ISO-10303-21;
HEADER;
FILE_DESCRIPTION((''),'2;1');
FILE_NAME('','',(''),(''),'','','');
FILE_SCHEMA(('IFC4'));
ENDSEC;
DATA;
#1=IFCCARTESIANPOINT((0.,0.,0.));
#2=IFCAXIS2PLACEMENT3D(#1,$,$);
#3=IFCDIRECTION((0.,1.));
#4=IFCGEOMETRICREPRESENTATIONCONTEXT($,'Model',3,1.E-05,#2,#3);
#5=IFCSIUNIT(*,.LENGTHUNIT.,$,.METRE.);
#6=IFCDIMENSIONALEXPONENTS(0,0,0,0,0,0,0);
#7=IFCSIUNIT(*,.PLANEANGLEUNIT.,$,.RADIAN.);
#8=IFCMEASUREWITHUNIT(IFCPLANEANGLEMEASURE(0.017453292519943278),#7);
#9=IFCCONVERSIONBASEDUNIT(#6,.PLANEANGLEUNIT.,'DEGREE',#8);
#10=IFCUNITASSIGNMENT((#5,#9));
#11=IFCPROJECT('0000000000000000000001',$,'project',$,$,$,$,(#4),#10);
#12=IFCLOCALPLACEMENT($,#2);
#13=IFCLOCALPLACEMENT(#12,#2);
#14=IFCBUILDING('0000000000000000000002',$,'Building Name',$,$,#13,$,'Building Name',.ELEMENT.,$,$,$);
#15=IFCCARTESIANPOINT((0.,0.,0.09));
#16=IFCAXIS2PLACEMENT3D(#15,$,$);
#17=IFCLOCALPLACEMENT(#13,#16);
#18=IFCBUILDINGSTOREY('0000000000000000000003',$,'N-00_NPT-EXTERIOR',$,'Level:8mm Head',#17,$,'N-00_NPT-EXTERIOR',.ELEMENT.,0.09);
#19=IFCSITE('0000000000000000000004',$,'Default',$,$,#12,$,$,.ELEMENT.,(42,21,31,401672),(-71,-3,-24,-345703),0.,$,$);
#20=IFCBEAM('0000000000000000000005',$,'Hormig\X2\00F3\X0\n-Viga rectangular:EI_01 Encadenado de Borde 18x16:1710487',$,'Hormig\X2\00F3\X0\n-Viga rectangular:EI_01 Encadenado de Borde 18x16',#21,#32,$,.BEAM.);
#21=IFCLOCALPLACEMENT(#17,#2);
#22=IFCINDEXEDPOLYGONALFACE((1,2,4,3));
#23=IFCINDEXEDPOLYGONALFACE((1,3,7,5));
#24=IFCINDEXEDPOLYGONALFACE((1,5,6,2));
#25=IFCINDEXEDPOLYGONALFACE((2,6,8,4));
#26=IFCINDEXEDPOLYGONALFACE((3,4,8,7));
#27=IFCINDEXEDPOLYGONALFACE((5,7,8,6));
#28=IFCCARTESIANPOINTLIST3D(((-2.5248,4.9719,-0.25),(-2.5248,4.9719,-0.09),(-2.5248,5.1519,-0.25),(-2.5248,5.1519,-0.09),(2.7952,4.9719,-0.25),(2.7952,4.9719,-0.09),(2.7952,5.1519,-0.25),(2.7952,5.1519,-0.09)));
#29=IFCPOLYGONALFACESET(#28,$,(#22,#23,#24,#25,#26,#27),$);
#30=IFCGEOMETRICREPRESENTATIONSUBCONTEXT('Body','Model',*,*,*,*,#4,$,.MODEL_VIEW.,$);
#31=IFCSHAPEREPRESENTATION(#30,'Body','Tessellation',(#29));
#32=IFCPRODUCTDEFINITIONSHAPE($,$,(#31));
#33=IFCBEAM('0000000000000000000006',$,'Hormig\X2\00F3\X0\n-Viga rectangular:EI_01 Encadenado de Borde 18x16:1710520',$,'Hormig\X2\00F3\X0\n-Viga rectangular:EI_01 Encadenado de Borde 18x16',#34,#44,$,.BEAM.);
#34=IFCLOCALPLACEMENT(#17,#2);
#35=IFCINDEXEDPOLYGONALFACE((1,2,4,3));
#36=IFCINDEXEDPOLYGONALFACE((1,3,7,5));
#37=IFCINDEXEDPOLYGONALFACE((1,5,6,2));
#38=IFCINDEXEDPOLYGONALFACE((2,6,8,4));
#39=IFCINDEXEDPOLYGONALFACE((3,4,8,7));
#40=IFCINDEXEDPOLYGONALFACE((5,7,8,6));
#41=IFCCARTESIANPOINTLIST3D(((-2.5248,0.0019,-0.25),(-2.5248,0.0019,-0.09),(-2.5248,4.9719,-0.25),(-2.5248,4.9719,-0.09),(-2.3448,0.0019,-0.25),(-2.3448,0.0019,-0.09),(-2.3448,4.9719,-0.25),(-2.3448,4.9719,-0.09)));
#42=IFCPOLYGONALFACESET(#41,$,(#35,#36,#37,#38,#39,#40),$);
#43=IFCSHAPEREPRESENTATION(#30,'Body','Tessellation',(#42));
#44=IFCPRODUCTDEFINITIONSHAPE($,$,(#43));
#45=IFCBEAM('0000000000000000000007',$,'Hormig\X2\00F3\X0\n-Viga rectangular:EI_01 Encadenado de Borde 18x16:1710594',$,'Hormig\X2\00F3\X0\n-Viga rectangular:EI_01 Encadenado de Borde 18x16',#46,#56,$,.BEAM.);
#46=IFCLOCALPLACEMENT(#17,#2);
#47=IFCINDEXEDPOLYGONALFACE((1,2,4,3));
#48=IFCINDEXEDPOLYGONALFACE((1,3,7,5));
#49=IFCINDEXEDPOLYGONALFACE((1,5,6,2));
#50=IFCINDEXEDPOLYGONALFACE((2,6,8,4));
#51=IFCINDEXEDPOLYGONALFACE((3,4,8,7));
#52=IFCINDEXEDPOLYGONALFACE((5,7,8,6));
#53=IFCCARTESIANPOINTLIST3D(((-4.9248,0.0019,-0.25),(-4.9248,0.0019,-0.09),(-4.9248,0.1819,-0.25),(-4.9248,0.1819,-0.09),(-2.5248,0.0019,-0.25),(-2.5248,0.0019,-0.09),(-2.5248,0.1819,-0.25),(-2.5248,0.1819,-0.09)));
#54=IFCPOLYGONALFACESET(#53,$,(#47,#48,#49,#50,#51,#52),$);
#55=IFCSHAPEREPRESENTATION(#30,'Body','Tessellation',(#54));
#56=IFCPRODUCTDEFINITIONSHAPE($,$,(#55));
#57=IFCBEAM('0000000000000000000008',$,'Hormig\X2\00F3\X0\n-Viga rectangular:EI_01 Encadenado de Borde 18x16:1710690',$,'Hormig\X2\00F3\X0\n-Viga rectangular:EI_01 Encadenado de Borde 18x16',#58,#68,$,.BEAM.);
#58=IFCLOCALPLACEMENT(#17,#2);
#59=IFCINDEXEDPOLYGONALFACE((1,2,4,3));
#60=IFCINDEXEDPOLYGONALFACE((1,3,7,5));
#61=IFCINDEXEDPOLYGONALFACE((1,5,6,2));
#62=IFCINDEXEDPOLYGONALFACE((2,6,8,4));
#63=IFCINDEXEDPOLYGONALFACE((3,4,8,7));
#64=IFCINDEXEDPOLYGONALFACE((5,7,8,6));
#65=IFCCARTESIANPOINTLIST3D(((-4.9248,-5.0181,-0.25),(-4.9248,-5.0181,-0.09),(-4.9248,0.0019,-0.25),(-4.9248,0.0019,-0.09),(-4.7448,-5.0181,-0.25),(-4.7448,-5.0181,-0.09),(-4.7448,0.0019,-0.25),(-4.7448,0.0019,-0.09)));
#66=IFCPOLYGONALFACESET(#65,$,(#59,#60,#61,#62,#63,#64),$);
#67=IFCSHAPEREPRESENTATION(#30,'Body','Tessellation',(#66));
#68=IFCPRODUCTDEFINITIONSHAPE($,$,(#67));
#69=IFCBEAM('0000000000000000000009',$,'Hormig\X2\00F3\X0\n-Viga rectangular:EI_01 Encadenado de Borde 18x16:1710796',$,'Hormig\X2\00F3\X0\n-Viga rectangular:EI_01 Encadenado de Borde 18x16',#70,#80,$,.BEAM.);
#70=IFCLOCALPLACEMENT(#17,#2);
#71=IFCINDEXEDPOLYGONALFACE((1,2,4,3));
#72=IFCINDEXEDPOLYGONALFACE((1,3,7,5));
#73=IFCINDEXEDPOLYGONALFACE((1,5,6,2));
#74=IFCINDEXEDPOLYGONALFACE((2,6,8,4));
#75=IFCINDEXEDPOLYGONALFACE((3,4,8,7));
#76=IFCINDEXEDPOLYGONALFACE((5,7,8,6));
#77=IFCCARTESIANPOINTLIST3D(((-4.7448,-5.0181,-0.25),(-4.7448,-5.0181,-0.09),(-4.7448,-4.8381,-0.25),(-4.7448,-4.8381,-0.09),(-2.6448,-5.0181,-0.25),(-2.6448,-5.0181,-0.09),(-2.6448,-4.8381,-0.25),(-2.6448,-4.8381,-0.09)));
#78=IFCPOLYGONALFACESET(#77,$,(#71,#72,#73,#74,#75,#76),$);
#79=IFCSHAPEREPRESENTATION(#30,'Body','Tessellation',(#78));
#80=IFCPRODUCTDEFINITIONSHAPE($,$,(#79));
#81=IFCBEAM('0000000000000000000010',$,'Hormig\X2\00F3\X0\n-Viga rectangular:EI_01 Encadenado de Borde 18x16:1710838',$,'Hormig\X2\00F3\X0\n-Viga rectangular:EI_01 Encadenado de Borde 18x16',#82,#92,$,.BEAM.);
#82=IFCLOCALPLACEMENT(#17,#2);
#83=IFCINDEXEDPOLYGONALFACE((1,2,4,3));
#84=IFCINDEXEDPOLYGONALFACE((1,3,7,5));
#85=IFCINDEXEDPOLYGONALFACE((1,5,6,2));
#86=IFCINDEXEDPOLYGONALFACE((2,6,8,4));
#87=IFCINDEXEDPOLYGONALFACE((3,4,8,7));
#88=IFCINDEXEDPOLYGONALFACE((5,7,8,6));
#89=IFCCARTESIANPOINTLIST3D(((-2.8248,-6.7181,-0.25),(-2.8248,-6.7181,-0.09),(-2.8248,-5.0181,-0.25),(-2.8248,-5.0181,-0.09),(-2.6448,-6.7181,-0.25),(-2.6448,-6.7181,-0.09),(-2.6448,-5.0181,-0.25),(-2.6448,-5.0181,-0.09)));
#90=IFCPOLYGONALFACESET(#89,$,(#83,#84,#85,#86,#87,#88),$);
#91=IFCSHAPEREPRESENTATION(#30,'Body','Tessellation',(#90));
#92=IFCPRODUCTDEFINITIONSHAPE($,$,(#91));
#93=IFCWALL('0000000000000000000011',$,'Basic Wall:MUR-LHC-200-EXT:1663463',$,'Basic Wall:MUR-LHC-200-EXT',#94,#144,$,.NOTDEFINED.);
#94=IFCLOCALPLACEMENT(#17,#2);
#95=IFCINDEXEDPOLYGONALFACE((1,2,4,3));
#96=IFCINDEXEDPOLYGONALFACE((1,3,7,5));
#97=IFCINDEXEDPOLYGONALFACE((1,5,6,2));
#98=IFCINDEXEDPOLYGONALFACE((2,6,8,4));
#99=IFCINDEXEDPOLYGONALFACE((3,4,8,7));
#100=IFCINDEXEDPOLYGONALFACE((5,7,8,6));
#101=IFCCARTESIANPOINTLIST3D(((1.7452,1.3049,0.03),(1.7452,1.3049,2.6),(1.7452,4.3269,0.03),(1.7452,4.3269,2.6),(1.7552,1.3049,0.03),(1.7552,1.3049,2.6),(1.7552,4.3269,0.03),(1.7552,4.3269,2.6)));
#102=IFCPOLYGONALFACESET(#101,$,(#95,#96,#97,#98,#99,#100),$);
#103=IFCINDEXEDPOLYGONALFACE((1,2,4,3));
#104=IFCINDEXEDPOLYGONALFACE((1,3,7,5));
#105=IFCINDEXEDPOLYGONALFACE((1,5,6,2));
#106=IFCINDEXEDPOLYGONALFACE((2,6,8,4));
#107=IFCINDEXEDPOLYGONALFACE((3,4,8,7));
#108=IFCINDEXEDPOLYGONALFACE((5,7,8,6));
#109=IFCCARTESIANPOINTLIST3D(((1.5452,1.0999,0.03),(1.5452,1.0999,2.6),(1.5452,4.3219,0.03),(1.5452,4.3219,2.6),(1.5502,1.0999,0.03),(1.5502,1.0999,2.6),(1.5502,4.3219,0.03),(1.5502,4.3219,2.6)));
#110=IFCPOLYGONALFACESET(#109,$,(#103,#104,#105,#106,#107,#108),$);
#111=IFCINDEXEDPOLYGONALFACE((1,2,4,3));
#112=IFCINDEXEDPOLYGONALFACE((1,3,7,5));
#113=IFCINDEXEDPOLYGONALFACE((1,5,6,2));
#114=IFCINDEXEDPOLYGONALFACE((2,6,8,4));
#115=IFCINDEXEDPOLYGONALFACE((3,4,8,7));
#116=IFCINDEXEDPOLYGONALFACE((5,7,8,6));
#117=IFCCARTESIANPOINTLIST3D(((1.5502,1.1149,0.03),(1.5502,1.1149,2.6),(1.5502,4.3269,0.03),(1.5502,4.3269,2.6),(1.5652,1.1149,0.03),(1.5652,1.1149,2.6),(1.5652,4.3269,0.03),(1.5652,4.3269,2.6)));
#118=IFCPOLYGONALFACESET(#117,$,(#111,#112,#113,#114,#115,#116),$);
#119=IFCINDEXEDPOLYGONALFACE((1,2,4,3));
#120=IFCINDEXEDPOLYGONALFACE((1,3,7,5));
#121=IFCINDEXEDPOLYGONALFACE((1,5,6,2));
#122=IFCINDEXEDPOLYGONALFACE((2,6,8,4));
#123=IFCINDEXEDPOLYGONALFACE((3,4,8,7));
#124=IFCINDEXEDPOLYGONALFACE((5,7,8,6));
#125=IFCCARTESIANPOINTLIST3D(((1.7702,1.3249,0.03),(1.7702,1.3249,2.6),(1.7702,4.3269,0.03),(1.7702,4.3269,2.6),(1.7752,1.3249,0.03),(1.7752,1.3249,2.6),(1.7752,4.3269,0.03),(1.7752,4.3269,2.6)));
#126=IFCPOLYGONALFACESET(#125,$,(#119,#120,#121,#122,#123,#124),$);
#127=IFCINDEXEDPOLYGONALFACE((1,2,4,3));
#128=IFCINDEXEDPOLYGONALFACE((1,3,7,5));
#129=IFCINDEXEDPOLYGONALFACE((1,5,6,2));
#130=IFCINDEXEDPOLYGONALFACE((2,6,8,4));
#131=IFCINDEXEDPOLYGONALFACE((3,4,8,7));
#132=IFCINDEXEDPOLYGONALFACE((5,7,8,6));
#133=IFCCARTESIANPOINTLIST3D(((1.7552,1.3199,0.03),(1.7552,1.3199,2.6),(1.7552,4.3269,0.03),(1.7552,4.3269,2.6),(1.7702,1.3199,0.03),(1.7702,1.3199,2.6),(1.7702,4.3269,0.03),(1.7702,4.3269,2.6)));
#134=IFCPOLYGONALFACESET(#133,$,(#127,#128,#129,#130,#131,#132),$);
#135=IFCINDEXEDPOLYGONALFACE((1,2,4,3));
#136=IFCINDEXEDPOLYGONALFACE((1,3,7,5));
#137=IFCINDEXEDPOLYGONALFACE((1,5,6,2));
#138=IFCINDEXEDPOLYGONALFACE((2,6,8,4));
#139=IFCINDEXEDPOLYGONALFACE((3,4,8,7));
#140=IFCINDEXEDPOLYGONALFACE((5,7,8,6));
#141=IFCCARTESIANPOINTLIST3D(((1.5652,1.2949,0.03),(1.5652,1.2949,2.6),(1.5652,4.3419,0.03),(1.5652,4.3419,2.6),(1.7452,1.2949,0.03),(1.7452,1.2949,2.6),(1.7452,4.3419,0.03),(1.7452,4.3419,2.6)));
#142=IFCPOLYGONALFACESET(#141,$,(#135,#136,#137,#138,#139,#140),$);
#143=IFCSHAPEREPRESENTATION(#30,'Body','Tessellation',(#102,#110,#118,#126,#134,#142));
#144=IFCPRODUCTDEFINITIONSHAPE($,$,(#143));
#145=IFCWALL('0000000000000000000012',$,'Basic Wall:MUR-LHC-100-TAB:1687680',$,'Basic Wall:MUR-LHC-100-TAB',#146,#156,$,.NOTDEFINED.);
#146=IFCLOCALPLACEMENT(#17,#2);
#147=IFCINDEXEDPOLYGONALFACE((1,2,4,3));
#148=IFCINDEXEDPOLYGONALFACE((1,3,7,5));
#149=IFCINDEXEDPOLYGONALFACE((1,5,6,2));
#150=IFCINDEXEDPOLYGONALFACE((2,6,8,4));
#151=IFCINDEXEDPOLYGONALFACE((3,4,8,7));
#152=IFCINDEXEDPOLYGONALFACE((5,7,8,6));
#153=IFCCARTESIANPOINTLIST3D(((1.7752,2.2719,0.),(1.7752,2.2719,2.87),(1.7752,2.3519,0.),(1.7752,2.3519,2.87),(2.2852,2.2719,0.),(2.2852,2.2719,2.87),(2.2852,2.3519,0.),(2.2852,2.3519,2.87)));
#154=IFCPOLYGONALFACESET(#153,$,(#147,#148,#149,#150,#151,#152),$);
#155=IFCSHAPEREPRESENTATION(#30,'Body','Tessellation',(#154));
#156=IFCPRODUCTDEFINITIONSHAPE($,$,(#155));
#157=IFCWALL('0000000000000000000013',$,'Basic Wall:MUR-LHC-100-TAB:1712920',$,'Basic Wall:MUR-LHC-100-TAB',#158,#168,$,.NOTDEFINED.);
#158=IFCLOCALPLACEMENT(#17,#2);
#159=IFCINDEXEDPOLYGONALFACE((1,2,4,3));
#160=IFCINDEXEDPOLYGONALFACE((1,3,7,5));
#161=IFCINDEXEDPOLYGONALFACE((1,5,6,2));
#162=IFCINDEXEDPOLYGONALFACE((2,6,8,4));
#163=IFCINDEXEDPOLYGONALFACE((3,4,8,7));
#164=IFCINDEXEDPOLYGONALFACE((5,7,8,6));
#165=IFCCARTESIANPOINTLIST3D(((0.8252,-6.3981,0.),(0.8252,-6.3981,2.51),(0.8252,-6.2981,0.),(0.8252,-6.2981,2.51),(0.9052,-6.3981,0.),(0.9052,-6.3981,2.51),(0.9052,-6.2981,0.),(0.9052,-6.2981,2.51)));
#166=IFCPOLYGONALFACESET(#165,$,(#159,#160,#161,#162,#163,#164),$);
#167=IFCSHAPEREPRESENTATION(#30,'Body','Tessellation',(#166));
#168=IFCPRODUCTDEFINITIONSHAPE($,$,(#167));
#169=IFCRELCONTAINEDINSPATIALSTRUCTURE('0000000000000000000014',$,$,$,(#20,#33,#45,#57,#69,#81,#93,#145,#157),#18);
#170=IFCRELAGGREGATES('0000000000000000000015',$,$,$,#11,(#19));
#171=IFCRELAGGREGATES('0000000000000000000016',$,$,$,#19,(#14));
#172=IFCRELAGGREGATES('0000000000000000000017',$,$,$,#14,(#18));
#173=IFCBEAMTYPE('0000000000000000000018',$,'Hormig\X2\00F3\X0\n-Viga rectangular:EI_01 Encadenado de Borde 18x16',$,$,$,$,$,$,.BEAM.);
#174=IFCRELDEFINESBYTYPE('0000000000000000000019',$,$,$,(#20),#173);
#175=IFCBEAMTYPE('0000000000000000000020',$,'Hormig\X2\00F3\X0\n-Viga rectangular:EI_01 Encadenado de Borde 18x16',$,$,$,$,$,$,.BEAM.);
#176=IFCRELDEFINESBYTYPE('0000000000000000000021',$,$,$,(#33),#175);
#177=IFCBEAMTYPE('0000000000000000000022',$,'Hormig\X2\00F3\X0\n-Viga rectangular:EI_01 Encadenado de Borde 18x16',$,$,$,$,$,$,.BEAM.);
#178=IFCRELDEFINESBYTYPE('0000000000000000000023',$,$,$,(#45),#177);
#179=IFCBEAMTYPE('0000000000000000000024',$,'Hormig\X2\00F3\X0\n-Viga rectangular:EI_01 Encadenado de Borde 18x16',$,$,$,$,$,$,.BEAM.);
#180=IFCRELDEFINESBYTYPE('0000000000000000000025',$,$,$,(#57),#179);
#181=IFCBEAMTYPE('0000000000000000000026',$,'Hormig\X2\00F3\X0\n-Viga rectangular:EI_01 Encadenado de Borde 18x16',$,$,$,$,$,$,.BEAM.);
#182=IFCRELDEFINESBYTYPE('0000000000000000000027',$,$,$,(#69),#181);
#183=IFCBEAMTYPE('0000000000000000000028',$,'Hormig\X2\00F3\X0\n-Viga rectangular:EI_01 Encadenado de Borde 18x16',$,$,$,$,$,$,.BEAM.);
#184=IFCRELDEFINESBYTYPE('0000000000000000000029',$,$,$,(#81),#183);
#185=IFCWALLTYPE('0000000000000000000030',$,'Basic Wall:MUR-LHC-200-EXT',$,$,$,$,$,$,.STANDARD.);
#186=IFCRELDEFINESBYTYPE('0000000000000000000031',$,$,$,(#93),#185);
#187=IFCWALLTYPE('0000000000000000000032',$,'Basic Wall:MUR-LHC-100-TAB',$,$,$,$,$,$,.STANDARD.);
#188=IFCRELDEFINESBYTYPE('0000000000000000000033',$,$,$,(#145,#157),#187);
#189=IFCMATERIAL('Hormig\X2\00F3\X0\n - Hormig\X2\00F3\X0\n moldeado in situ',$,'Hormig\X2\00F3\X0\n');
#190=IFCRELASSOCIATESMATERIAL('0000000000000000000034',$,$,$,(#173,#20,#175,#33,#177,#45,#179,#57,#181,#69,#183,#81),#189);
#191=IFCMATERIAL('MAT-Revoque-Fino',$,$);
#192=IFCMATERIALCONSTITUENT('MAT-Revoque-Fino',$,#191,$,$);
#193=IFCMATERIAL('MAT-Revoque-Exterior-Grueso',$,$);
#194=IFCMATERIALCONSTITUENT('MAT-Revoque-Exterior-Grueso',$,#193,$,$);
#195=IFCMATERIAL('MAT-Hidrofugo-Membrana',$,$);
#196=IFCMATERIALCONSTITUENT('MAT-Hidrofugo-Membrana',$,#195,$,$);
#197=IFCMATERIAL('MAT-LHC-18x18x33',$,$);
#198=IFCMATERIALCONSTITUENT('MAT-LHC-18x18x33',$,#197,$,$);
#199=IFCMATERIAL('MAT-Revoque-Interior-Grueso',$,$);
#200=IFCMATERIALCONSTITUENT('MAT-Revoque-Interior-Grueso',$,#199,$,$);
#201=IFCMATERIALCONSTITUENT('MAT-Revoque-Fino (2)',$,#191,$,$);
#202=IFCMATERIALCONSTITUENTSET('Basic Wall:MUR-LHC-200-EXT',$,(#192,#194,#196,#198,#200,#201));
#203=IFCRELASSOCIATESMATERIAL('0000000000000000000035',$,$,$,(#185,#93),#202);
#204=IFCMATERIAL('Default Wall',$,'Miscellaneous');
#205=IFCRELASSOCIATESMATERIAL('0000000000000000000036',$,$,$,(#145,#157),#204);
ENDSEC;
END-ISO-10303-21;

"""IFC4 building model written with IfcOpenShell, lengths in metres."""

from ifc_helpers import new_model, entity, si_unit, converted_unit, direction, frame, origin, place, context, subcontext, project, spatial, indexed_curve, outline, extrude, source, transform, mapped, material, constituent, constituent_set, type_object, type_shapes, element, save


model = new_model("IFC4")

# Units and contexts
model_context = context("Model", 3, precision=1e-05, world=origin(), true_north=direction((0.0, 1.0)))
body_context = subcontext(model_context, "Body", "Model", "MODEL_VIEW")
ifc_project = project(units=[si_unit("LENGTHUNIT", "METRE"), converted_unit("PLANEANGLEUNIT", "DEGREE", entity("IfcPlaneAngleMeasure", 0.017453292519943278), si_unit("PLANEANGLEUNIT", "RADIAN"), dimensions=[0, 0, 0, 0, 0, 0, 0])], contexts=[model_context])

# Site, building, storey
site_placement = place(None, origin())
site = spatial("IfcSite", under=ifc_project, at=site_placement, Name="Default", CompositionType="ELEMENT", RefLatitude=(42, 21, 31, 401672), RefLongitude=(-71, -3, -24, -345703), RefElevation=0.0)
building_placement = place(site_placement, origin())
building = spatial("IfcBuilding", under=site, at=building_placement, Name="Building Name", LongName="Building Name", CompositionType="ELEMENT")
storey_placement = place(building_placement, frame((0.0, 0.0, 0.09)))
storey = spatial("IfcBuildingStorey", under=building, at=storey_placement, Name="N-00_NPT-EXTERIOR", ObjectType="Level:8mm Head", LongName="N-00_NPT-EXTERIOR", CompositionType="ELEMENT", Elevation=0.09)

# Beams
ifc_material_1 = material(Name="Hormigón - Hormigón moldeado in situ", Category="Hormigón")
beam_type_1 = type_object("IfcBeamType", Name="Hormigón-Viga rectangular:EI_01 Encadenado de Borde 18x16", PredefinedType="BEAM", material=ifc_material_1)
shared_shape_1 = source(origin(), body_context, "Body", "SweptSolid", [
    extrude(outline(indexed_curve([(-0.08, -0.09), (0.08, -0.09), (0.08, 0.09), (-0.08, 0.09), (-0.08, -0.09)], self_intersect=False)), frame((2.7952, 5.0619, -0.08), z_axis=(-1.0, 0.0, 0.0), x_axis=(0.0, 0.0, -1.0)), (0.0, 0.0, 1.0), 5.32),
])
type_shapes(beam_type_1, [shared_shape_1])
beam_1_placement = place(storey_placement, frame((0.0, 0.0, -0.09)))
element("IfcBeam", 1, at=beam_1_placement, inside=storey, type_object=beam_type_1, material=ifc_material_1, Name="Hormigón-Viga rectangular:EI_01 Encadenado de Borde 18x16:1710487", ObjectType="Hormigón-Viga rectangular:EI_01 Encadenado de Borde 18x16", PredefinedType="BEAM", context=body_context, shape_type="MappedRepresentation", body=[
    mapped(shared_shape_1, transform((0.0, 0.0, 0.0), scale=1.0)),
])
beam_type_2 = type_object("IfcBeamType", Name="Hormigón-Viga rectangular:EI_01 Encadenado de Borde 18x16", PredefinedType="BEAM", material=ifc_material_1)
shared_shape_2 = source(origin(), body_context, "Body", "SweptSolid", [
    extrude(outline(indexed_curve([(-0.09, -0.08), (0.09, -0.08), (0.09, 0.08), (-0.09, 0.08), (-0.09, -0.08)], self_intersect=False)), frame((-2.4348, 4.9719, -0.08), z_axis=(0.0, -1.0, 0.0), x_axis=(-1.0, 0.0, 0.0)), (0.0, 0.0, 1.0), 4.97),
])
type_shapes(beam_type_2, [shared_shape_2])
beam_2_placement = place(storey_placement, frame((0.0, 0.0, -0.09)))
element("IfcBeam", 2, at=beam_2_placement, inside=storey, type_object=beam_type_2, material=ifc_material_1, Name="Hormigón-Viga rectangular:EI_01 Encadenado de Borde 18x16:1710520", ObjectType="Hormigón-Viga rectangular:EI_01 Encadenado de Borde 18x16", PredefinedType="BEAM", context=body_context, shape_type="MappedRepresentation", body=[
    mapped(shared_shape_2, transform((0.0, 0.0, 0.0), scale=1.0)),
])
beam_type_3 = type_object("IfcBeamType", Name="Hormigón-Viga rectangular:EI_01 Encadenado de Borde 18x16", PredefinedType="BEAM", material=ifc_material_1)
shared_shape_3 = source(origin(), body_context, "Body", "SweptSolid", [
    extrude(outline(indexed_curve([(-0.08, -0.09), (0.08, -0.09), (0.08, 0.09), (-0.08, 0.09), (-0.08, -0.09)], self_intersect=False)), frame((-2.5248, 0.0919, -0.08), z_axis=(-1.0, 0.0, 0.0), x_axis=(0.0, 0.0, -1.0)), (0.0, 0.0, 1.0), 2.4),
])
type_shapes(beam_type_3, [shared_shape_3])
beam_3_placement = place(storey_placement, frame((0.0, 0.0, -0.09)))
element("IfcBeam", 3, at=beam_3_placement, inside=storey, type_object=beam_type_3, material=ifc_material_1, Name="Hormigón-Viga rectangular:EI_01 Encadenado de Borde 18x16:1710594", ObjectType="Hormigón-Viga rectangular:EI_01 Encadenado de Borde 18x16", PredefinedType="BEAM", context=body_context, shape_type="MappedRepresentation", body=[
    mapped(shared_shape_3, transform((0.0, 0.0, 0.0), scale=1.0)),
])
beam_type_4 = type_object("IfcBeamType", Name="Hormigón-Viga rectangular:EI_01 Encadenado de Borde 18x16", PredefinedType="BEAM", material=ifc_material_1)
shared_shape_4 = source(origin(), body_context, "Body", "SweptSolid", [
    extrude(outline(indexed_curve([(-0.09, -0.08), (0.09, -0.08), (0.09, 0.08), (-0.09, 0.08), (-0.09, -0.08)], self_intersect=False)), frame((-4.8348, 0.0019, -0.08), z_axis=(0.0, -1.0, 0.0), x_axis=(-1.0, 0.0, 0.0)), (0.0, 0.0, 1.0), 5.02),
])
type_shapes(beam_type_4, [shared_shape_4])
beam_4_placement = place(storey_placement, frame((0.0, 0.0, -0.09)))
element("IfcBeam", 4, at=beam_4_placement, inside=storey, type_object=beam_type_4, material=ifc_material_1, Name="Hormigón-Viga rectangular:EI_01 Encadenado de Borde 18x16:1710690", ObjectType="Hormigón-Viga rectangular:EI_01 Encadenado de Borde 18x16", PredefinedType="BEAM", context=body_context, shape_type="MappedRepresentation", body=[
    mapped(shared_shape_4, transform((0.0, 0.0, 0.0), scale=1.0)),
])
beam_type_5 = type_object("IfcBeamType", Name="Hormigón-Viga rectangular:EI_01 Encadenado de Borde 18x16", PredefinedType="BEAM", material=ifc_material_1)
shared_shape_5 = source(origin(), body_context, "Body", "SweptSolid", [
    extrude(outline(indexed_curve([(-0.08, -0.09), (0.08, -0.09), (0.08, 0.09), (-0.08, 0.09), (-0.08, -0.09)], self_intersect=False)), frame((-4.7448, -4.9281, -0.08), z_axis=(1.0, 0.0, 0.0), x_axis=(0.0, 0.0, -1.0)), (0.0, 0.0, 1.0), 2.1),
])
type_shapes(beam_type_5, [shared_shape_5])
beam_5_placement = place(storey_placement, frame((0.0, 0.0, -0.09)))
element("IfcBeam", 5, at=beam_5_placement, inside=storey, type_object=beam_type_5, material=ifc_material_1, Name="Hormigón-Viga rectangular:EI_01 Encadenado de Borde 18x16:1710796", ObjectType="Hormigón-Viga rectangular:EI_01 Encadenado de Borde 18x16", PredefinedType="BEAM", context=body_context, shape_type="MappedRepresentation", body=[
    mapped(shared_shape_5, transform((0.0, 0.0, 0.0), scale=1.0)),
])
beam_type_6 = type_object("IfcBeamType", Name="Hormigón-Viga rectangular:EI_01 Encadenado de Borde 18x16", PredefinedType="BEAM", material=ifc_material_1)
shared_shape_6 = source(origin(), body_context, "Body", "SweptSolid", [
    extrude(outline(indexed_curve([(-0.09, -0.08), (0.09, -0.08), (0.09, 0.08), (-0.09, 0.08), (-0.09, -0.08)], self_intersect=False)), frame((-2.7348, -5.0181, -0.08), z_axis=(0.0, -1.0, 0.0), x_axis=(-1.0, 0.0, 0.0)), (0.0, 0.0, 1.0), 1.7),
])
type_shapes(beam_type_6, [shared_shape_6])
beam_6_placement = place(storey_placement, frame((0.0, 0.0, -0.09)))
element("IfcBeam", 6, at=beam_6_placement, inside=storey, type_object=beam_type_6, material=ifc_material_1, Name="Hormigón-Viga rectangular:EI_01 Encadenado de Borde 18x16:1710838", ObjectType="Hormigón-Viga rectangular:EI_01 Encadenado de Borde 18x16", PredefinedType="BEAM", context=body_context, shape_type="MappedRepresentation", body=[
    mapped(shared_shape_6, transform((0.0, 0.0, 0.0), scale=1.0)),
])

# Shared definitions
ifc_material_2 = material(Name="MAT-Revoque-Fino")
ifc_constituent_1 = constituent(ifc_material_2, Name="MAT-Revoque-Fino")
ifc_material_3 = material(Name="MAT-Revoque-Exterior-Grueso")
ifc_constituent_2 = constituent(ifc_material_3, Name="MAT-Revoque-Exterior-Grueso")
ifc_material_4 = material(Name="MAT-Hidrofugo-Membrana")
ifc_constituent_3 = constituent(ifc_material_4, Name="MAT-Hidrofugo-Membrana")
ifc_material_5 = material(Name="MAT-LHC-18x18x33")
ifc_constituent_4 = constituent(ifc_material_5, Name="MAT-LHC-18x18x33")
ifc_material_6 = material(Name="MAT-Revoque-Interior-Grueso")
ifc_constituent_5 = constituent(ifc_material_6, Name="MAT-Revoque-Interior-Grueso")
ifc_constituent_6 = constituent(ifc_material_2, Name="MAT-Revoque-Fino (2)")
ifc_constituent_set_1 = constituent_set(constituents=[ifc_constituent_1, ifc_constituent_2, ifc_constituent_3, ifc_constituent_4, ifc_constituent_5, ifc_constituent_6], Name="Basic Wall:MUR-LHC-200-EXT")
wall_type_1 = type_object("IfcWallType", Name="Basic Wall:MUR-LHC-200-EXT", PredefinedType="STANDARD", material=ifc_constituent_set_1)

# Wall
wall_1_placement = place(storey_placement, frame((1.6602, 4.3219, 0.03), z_axis=(0.0, 0.0, 1.0), x_axis=(0.0, -1.0, 0.0)))
element("IfcWall", 7, at=wall_1_placement, inside=storey, type_object=wall_type_1, material=ifc_constituent_set_1, Name="Basic Wall:MUR-LHC-200-EXT:1663463", ObjectType="Basic Wall:MUR-LHC-200-EXT", PredefinedType="NOTDEFINED", context=body_context, shape_type="SweptSolid", body=[
    extrude(outline(indexed_curve([(-0.005, -1.511), (0.005, -1.511), (0.005, 1.511), (-0.005, 1.511), (-0.005, -1.511)], self_intersect=False)), frame((1.506, 0.09, 0.0), z_axis=(0.0, 0.0, 1.0), x_axis=(0.0, -1.0, 0.0)), (0.0, 0.0, 1.0), 2.57),
    extrude(outline(indexed_curve([(-0.0025, -1.611), (0.0025, -1.611), (0.0025, 1.611), (-0.0025, 1.611), (-0.0025, -1.611)], self_intersect=False)), frame((1.611, -0.1125, 0.0), z_axis=(0.0, 0.0, 1.0), x_axis=(0.0, -1.0, 0.0)), (0.0, 0.0, 1.0), 2.57),
    extrude(outline(indexed_curve([(-0.0075, -1.606), (0.0075, -1.606), (0.0075, 1.606), (-0.0075, 1.606), (-0.0075, -1.606)], self_intersect=False)), frame((1.601, -0.1025, 0.0), z_axis=(0.0, 0.0, 1.0), x_axis=(0.0, 1.0, 0.0)), (0.0, 0.0, 1.0), 2.57),
    extrude(outline(indexed_curve([(-0.0025, -1.501), (0.0025, -1.501), (0.0025, 1.501), (-0.0025, 1.501), (-0.0025, -1.501)], self_intersect=False)), frame((1.496, 0.1125, 0.0), z_axis=(0.0, 0.0, 1.0), x_axis=(0.0, 1.0, 0.0)), (0.0, 0.0, 1.0), 2.57),
    extrude(outline(indexed_curve([(-0.0075, -1.5035), (0.0075, -1.5035), (0.0075, 1.5035), (-0.0075, 1.5035), (-0.0075, -1.5035)], self_intersect=False)), frame((1.4985, 0.1025, 0.0), z_axis=(0.0, 0.0, 1.0), x_axis=(0.0, 1.0, 0.0)), (0.0, 0.0, 1.0), 2.57),
    extrude(outline(indexed_curve([(-0.09, -1.5235), (0.09, -1.5235), (0.09, 1.5235), (-0.09, 1.5235), (-0.09, -1.5235)], self_intersect=False)), frame((1.5035, -0.005, 0.0), z_axis=(0.0, 0.0, 1.0), x_axis=(0.0, -1.0, 0.0)), (0.0, 0.0, 1.0), 2.57),
])

# Walls
ifc_material_7 = material(Name="Default Wall", Category="Miscellaneous")
wall_type_2 = type_object("IfcWallType", Name="Basic Wall:MUR-LHC-100-TAB", PredefinedType="STANDARD")
wall_2_placement = place(storey_placement, frame((1.7752, 2.3119, 0.0)))
element("IfcWall", 8, at=wall_2_placement, inside=storey, type_object=wall_type_2, material=ifc_material_7, Name="Basic Wall:MUR-LHC-100-TAB:1687680", ObjectType="Basic Wall:MUR-LHC-100-TAB", PredefinedType="NOTDEFINED", context=body_context, shape_type="SweptSolid", body=[
    extrude(outline(indexed_curve([(0.51, 0.04), (0.0, 0.04), (0.0, -0.04), (0.51, -0.04), (0.51, 0.04)], self_intersect=False)), origin(), (0.0, 0.0, 1.0), 2.87),
])
wall_3_placement = place(storey_placement, frame((0.8652, -6.2981, 0.0), z_axis=(0.0, 0.0, 1.0), x_axis=(0.0, -1.0, 0.0)))
element("IfcWall", 9, at=wall_3_placement, inside=storey, type_object=wall_type_2, material=ifc_material_7, Name="Basic Wall:MUR-LHC-100-TAB:1712920", ObjectType="Basic Wall:MUR-LHC-100-TAB", PredefinedType="NOTDEFINED", context=body_context, shape_type="SweptSolid", body=[
    extrude(outline(indexed_curve([(0.1, 0.04), (0.0, 0.04), (0.0, -0.04), (0.1, -0.04), (0.1, 0.04)], self_intersect=False)), origin(), (0.0, 0.0, 1.0), 2.51),
])

save(model, "model.ifc")
